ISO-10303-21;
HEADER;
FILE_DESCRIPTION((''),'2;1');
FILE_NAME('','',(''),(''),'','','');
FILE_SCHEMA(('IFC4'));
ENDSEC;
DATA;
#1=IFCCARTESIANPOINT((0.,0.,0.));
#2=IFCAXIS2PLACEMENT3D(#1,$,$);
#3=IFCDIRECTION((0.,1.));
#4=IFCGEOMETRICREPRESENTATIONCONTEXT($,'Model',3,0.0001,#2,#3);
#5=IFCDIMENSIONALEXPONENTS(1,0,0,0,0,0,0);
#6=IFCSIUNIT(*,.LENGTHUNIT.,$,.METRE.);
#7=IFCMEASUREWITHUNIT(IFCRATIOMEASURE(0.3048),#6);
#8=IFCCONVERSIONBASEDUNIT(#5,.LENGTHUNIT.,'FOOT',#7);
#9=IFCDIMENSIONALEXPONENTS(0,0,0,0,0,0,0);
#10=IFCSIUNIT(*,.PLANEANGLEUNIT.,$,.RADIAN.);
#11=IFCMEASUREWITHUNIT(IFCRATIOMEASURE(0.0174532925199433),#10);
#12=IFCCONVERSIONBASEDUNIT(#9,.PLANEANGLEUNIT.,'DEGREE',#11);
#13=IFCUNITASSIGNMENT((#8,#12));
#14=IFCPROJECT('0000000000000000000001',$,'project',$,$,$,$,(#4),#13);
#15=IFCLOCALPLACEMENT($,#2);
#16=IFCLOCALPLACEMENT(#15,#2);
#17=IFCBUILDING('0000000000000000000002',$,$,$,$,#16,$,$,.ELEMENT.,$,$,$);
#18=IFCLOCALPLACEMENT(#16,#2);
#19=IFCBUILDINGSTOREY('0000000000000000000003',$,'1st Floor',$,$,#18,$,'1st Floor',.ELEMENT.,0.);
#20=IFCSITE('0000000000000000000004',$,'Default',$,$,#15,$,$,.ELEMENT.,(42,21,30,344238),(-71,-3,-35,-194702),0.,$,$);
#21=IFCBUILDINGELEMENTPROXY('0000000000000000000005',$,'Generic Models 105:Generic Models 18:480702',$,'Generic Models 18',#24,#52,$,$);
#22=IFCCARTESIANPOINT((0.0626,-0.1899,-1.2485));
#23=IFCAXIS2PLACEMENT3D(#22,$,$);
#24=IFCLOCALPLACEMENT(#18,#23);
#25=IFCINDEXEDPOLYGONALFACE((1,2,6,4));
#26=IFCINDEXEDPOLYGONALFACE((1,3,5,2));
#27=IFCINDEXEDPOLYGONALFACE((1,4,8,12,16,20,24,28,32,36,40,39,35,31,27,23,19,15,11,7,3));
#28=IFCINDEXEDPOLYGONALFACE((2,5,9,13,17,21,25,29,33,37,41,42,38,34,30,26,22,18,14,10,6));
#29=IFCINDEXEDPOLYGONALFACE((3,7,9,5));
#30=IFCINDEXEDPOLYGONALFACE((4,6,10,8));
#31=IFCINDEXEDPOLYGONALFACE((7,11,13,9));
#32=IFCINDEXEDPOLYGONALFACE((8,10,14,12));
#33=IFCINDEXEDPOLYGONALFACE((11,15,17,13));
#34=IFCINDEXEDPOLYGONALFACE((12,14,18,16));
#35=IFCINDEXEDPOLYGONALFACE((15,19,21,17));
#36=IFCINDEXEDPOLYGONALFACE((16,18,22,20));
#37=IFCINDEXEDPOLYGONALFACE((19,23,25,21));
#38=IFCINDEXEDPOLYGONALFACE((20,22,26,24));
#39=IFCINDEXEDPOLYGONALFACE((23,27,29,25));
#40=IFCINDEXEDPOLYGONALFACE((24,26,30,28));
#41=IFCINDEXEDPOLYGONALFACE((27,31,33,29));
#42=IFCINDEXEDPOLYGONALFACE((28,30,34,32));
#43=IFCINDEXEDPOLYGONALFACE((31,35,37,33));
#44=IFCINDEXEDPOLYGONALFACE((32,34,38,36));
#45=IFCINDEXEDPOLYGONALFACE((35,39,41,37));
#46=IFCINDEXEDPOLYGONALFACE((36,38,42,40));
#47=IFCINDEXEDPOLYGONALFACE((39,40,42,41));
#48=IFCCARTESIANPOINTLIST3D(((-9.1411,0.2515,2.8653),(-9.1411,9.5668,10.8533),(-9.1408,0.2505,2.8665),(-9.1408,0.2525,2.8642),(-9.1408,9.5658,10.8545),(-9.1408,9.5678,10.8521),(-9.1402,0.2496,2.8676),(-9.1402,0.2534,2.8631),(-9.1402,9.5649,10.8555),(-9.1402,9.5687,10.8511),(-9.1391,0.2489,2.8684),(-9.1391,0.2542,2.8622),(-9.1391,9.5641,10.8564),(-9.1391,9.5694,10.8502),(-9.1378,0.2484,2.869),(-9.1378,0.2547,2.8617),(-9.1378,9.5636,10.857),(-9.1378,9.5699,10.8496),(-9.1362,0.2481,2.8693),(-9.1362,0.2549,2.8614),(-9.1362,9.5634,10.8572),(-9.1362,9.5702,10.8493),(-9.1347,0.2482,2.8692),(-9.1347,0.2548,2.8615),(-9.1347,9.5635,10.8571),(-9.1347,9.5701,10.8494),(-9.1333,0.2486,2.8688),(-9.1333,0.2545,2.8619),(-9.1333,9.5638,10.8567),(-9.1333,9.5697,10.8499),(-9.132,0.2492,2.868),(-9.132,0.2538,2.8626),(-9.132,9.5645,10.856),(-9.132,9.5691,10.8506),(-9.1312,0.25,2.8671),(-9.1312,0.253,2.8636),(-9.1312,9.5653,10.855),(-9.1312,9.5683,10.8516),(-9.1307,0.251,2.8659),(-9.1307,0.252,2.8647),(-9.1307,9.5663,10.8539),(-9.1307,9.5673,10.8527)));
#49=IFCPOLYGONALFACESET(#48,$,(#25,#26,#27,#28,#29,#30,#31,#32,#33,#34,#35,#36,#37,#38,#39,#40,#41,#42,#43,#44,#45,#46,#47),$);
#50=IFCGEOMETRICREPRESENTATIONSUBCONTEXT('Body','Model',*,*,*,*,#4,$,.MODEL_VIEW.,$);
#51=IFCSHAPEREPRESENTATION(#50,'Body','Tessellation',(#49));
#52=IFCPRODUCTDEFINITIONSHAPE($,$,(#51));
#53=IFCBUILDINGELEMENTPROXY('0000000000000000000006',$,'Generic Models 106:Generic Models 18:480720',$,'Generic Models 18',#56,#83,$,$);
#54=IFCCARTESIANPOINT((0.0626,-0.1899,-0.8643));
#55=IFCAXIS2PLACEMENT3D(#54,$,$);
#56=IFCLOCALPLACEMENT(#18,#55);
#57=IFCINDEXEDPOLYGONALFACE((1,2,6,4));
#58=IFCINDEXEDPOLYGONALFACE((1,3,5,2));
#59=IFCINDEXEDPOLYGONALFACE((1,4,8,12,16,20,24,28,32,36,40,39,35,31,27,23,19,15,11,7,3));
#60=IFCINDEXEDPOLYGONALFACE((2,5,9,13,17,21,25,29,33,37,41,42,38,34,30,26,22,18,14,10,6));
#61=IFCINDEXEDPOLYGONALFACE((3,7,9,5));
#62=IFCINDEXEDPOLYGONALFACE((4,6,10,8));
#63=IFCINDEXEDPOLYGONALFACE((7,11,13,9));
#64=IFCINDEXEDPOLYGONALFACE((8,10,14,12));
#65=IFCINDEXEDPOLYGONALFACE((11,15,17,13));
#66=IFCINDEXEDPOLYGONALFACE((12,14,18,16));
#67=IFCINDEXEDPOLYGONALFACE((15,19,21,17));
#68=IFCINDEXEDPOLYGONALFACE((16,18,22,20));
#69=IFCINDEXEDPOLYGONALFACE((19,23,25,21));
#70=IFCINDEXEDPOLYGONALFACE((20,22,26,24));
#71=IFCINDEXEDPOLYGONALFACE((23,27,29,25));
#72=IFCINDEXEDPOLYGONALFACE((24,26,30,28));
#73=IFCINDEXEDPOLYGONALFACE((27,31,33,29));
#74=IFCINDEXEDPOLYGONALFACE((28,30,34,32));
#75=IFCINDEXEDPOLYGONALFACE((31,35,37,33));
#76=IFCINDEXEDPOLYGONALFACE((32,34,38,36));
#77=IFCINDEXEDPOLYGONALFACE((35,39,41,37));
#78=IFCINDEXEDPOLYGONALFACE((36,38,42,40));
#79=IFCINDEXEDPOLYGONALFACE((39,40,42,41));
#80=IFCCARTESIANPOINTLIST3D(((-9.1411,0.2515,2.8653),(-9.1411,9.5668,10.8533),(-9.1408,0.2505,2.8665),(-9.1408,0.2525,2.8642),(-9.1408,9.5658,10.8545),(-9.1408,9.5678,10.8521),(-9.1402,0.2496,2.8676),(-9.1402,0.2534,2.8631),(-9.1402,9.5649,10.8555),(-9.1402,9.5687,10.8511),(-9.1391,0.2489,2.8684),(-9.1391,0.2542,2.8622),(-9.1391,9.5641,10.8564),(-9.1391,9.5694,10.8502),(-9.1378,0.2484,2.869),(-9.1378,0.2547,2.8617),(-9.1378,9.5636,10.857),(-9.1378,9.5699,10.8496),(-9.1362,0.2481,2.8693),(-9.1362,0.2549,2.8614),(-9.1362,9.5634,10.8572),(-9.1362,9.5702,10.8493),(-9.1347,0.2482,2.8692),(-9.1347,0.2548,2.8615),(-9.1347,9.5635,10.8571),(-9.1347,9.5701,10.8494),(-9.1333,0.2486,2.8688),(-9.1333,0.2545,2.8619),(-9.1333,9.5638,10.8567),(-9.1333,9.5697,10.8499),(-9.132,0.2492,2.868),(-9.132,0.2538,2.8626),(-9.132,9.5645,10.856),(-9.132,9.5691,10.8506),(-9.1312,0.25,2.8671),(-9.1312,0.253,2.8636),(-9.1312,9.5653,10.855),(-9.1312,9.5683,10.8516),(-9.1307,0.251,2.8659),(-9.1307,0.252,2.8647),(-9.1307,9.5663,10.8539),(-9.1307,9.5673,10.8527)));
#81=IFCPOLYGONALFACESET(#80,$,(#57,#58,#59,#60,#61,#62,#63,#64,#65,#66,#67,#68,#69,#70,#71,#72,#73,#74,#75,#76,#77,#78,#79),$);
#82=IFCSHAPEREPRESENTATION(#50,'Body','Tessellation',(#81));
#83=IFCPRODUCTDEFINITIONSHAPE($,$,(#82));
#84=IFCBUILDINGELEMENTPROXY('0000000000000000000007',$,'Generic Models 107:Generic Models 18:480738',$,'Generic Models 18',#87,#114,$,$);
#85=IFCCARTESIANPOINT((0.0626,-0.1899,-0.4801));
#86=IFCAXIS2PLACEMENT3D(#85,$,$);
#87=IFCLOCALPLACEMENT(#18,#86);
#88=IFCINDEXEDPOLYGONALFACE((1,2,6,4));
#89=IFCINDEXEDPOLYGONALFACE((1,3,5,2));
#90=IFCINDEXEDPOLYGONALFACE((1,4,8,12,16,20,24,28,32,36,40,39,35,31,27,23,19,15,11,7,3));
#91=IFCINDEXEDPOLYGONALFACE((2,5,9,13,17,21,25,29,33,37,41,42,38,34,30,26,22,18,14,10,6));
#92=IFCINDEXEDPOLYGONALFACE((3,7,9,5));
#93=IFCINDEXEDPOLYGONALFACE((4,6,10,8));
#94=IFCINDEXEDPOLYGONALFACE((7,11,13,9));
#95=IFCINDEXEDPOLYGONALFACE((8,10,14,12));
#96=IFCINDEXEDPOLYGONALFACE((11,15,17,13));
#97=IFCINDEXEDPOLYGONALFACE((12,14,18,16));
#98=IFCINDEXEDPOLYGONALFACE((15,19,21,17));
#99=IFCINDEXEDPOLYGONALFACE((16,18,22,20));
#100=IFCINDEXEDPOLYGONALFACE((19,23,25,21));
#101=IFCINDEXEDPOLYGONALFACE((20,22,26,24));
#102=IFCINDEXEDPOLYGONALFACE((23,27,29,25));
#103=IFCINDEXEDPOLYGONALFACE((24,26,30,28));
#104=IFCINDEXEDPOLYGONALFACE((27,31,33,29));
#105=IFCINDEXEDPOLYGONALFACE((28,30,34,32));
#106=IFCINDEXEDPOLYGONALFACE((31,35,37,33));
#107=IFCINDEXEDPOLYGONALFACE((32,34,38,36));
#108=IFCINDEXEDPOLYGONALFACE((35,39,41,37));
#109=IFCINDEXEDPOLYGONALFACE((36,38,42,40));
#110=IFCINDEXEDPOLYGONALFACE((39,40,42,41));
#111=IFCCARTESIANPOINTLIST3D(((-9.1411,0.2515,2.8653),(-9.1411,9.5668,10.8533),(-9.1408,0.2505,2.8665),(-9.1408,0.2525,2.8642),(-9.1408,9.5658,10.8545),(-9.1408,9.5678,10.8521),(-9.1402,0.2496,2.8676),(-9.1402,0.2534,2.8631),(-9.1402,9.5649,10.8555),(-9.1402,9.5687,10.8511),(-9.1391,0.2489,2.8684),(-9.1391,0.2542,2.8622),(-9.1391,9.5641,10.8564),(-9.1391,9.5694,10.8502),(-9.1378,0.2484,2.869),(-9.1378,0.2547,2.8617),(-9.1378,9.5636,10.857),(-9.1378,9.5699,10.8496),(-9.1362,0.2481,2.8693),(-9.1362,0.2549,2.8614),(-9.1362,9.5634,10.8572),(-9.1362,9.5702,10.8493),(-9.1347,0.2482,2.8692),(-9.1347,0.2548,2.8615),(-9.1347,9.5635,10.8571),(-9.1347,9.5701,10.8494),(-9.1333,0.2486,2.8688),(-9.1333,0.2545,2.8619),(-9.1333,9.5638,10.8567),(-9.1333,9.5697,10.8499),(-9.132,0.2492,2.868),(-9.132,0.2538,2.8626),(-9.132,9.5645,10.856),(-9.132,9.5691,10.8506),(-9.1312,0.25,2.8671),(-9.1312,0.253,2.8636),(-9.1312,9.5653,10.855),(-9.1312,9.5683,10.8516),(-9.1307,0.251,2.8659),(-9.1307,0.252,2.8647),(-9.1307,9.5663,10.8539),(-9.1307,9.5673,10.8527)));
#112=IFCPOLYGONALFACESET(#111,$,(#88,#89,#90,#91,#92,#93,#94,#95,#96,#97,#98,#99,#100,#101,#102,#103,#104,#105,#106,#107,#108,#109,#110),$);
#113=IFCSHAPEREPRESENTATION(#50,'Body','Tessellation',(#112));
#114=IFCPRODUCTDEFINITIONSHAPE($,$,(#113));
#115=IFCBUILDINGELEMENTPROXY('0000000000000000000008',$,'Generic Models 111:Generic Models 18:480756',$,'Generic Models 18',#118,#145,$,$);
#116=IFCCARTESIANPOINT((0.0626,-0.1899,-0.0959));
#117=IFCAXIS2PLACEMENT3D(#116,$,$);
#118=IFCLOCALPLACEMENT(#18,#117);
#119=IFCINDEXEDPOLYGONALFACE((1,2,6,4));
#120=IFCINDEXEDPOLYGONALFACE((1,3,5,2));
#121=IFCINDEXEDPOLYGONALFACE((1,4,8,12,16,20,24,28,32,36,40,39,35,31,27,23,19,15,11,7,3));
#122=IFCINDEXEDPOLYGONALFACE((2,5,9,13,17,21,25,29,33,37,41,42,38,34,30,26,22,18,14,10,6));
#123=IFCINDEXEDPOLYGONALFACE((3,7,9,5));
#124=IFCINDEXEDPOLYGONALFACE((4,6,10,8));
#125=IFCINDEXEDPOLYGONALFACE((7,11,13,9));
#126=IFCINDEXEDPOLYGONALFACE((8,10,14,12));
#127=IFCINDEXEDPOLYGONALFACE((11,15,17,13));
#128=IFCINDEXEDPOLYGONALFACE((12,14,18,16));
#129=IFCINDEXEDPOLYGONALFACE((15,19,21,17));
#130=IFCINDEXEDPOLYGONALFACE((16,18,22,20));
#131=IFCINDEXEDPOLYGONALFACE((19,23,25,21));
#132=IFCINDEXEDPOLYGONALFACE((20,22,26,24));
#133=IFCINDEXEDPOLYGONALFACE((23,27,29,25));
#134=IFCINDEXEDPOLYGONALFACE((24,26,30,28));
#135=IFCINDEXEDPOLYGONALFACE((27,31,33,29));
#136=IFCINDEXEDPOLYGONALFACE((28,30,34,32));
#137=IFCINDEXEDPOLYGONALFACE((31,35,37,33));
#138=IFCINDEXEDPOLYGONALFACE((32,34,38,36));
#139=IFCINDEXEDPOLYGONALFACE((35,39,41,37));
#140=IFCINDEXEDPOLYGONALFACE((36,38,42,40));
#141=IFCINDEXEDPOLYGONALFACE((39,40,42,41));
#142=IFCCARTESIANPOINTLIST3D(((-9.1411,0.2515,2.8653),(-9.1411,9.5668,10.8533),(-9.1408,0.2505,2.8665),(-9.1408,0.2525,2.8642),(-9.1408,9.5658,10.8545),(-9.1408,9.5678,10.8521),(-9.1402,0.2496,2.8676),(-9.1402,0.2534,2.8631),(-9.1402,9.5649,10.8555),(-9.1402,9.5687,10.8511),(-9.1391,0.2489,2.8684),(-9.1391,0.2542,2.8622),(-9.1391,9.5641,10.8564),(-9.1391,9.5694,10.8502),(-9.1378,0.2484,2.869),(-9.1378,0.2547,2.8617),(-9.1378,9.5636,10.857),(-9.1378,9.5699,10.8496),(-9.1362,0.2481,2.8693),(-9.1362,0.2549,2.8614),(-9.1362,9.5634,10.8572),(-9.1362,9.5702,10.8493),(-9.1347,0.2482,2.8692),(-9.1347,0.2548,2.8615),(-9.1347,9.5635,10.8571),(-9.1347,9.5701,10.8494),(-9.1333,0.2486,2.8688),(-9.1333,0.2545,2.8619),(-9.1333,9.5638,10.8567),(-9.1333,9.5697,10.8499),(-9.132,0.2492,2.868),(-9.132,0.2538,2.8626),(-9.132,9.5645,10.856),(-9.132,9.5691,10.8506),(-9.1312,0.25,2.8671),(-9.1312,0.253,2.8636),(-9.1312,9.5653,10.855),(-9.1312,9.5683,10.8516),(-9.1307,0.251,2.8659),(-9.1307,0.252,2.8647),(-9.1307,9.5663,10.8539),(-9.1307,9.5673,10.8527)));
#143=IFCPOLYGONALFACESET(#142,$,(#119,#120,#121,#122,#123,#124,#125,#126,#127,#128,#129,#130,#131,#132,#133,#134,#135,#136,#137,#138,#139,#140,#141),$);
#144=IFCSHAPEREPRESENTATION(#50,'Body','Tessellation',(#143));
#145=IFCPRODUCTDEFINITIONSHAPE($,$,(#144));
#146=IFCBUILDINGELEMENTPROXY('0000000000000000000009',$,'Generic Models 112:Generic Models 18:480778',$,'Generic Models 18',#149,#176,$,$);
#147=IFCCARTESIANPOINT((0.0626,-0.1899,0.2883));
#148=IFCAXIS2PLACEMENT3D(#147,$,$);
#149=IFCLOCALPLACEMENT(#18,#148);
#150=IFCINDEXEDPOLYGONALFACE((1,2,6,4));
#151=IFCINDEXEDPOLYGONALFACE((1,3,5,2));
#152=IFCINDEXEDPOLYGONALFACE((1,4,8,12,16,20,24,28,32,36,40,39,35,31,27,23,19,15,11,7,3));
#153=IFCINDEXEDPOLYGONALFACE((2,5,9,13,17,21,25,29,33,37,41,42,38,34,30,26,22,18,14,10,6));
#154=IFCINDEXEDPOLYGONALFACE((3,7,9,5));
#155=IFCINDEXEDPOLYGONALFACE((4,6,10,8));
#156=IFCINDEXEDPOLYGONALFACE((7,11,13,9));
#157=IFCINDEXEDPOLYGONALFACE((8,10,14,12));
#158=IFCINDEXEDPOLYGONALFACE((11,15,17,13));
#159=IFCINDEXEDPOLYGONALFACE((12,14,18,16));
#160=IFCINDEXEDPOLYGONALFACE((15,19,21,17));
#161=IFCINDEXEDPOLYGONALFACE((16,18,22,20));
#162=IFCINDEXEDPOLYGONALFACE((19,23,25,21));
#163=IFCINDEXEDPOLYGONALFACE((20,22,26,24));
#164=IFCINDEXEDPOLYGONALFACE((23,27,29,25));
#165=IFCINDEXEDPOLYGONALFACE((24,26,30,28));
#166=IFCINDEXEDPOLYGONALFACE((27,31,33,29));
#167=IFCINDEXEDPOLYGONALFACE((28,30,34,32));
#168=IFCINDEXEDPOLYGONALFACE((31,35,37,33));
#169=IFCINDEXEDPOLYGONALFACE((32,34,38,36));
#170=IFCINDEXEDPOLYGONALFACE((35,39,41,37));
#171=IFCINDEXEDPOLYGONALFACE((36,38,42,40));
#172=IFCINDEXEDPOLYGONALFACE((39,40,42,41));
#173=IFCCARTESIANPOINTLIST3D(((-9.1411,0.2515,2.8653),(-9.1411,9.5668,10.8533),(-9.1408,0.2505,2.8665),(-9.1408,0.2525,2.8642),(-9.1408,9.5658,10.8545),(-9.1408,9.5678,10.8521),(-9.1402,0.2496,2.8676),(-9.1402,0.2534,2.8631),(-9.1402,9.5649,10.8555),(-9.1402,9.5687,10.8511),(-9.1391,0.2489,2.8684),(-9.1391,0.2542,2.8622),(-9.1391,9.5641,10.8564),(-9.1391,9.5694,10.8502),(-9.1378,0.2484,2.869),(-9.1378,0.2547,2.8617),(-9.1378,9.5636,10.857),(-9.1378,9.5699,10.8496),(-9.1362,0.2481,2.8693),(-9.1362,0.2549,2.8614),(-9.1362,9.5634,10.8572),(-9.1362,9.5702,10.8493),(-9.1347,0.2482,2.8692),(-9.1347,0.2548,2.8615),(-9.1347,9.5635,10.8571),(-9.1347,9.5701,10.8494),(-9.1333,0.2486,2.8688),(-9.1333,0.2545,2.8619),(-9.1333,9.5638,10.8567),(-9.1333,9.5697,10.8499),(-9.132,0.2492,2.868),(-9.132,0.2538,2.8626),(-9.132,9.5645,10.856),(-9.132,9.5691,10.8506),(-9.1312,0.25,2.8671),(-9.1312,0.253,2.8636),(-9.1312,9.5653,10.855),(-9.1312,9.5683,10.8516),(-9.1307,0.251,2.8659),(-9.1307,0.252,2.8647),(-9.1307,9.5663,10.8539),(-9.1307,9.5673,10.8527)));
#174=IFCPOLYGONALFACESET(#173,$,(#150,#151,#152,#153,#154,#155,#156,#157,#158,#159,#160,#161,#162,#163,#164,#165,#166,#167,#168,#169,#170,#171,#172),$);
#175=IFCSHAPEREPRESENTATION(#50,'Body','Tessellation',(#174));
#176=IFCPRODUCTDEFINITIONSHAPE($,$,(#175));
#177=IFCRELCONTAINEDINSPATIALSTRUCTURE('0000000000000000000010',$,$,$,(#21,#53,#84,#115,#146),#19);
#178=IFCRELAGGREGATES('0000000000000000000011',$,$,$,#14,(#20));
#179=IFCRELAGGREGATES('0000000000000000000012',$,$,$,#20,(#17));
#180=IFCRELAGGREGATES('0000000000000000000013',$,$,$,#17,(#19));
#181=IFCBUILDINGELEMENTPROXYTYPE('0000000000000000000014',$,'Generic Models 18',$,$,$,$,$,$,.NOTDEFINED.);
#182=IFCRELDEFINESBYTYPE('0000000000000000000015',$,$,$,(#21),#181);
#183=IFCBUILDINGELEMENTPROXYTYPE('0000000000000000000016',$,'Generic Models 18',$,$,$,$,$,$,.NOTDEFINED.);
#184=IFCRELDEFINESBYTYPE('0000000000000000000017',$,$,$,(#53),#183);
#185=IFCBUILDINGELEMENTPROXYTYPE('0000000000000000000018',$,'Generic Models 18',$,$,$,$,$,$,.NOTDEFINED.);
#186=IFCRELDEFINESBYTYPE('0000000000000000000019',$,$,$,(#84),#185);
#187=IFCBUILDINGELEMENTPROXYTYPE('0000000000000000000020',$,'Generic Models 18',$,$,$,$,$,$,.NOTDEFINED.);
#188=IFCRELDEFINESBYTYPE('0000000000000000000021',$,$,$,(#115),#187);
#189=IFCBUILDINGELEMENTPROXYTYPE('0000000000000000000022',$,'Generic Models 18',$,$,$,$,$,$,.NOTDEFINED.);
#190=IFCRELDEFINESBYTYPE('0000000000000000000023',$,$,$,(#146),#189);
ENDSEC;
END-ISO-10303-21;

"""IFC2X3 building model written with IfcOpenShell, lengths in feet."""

from ifc_helpers import new_model, entity, si_unit, converted_unit, direction, frame, origin, origin_2d_with_axis, place, context, subcontext, project, spatial, circle, extrude, source, transform, mapped, type_object, type_shapes, element, save


model = new_model("IFC2X3")

# Units and contexts
model_context = context("Model", 3, precision=0.0001, world=origin(), true_north=direction((0.0, 1.0)))
body_context = subcontext(model_context, "Body", "Model", "MODEL_VIEW")
ifc_project = project(units=[converted_unit("LENGTHUNIT", "FOOT", entity("IfcRatioMeasure", 0.3048), si_unit("LENGTHUNIT", "METRE"), dimensions=[1, 0, 0, 0, 0, 0, 0]), converted_unit("PLANEANGLEUNIT", "DEGREE", entity("IfcRatioMeasure", 0.0174532925199433), si_unit("PLANEANGLEUNIT", "RADIAN"), dimensions=[0, 0, 0, 0, 0, 0, 0])], contexts=[model_context])

# Site, building, storey
site_placement = place(None, origin())
site = spatial("IfcSite", under=ifc_project, at=site_placement, Name="Default", CompositionType="ELEMENT", RefLatitude=(42, 21, 30, 344238), RefLongitude=(-71, -3, -35, -194702), RefElevation=0.0)
building_placement = place(site_placement, origin())
building = spatial("IfcBuilding", under=site, at=building_placement, CompositionType="ELEMENT")
storey_placement = place(building_placement, origin())
storey = spatial("IfcBuildingStorey", under=building, at=storey_placement, Name="1st Floor", LongName="1st Floor", CompositionType="ELEMENT", Elevation=0.0)

# Building element proxies
building_element_proxy_type_1 = type_object("IfcBuildingElementProxyType", Name="Generic Models 18", PredefinedType="NOTDEFINED")
shared_shape_1 = source(origin(), body_context, "Body", "SweptSolid", [
    extrude(circle(Radius=0.0052, at=origin_2d_with_axis()), frame((-9.1359, 0.2515, 2.8653), z_axis=(0.0, 0.759118, 0.650953), x_axis=(-1.0, 0.0, 0.0)), (0.0, 0.0, 1.0), 12.2712),
])
type_shapes(building_element_proxy_type_1, [shared_shape_1])
proxy_1_placement = place(storey_placement, frame((0.0626, -0.1899, -1.2485)))
element("IfcBuildingElementProxy", 1, at=proxy_1_placement, inside=storey, type_object=building_element_proxy_type_1, Name="Generic Models 105:Generic Models 18:480702", ObjectType="Generic Models 18", context=body_context, shape_type="MappedRepresentation", body=[
    mapped(shared_shape_1, transform((0.0, 0.0, 0.0), scale=1.0)),
])
building_element_proxy_type_2 = type_object("IfcBuildingElementProxyType", Name="Generic Models 18", PredefinedType="NOTDEFINED")
shared_shape_2 = source(origin(), body_context, "Body", "SweptSolid", [
    extrude(circle(Radius=0.0052, at=origin_2d_with_axis()), frame((-9.1359, 0.2515, 2.8653), z_axis=(0.0, 0.759118, 0.650953), x_axis=(-1.0, 0.0, 0.0)), (0.0, 0.0, 1.0), 12.2712),
])
type_shapes(building_element_proxy_type_2, [shared_shape_2])
proxy_2_placement = place(storey_placement, frame((0.0626, -0.1899, -0.8643)))
element("IfcBuildingElementProxy", 2, at=proxy_2_placement, inside=storey, type_object=building_element_proxy_type_2, Name="Generic Models 106:Generic Models 18:480720", ObjectType="Generic Models 18", context=body_context, shape_type="MappedRepresentation", body=[
    mapped(shared_shape_2, transform((0.0, 0.0, 0.0), scale=1.0)),
])
building_element_proxy_type_3 = type_object("IfcBuildingElementProxyType", Name="Generic Models 18", PredefinedType="NOTDEFINED")
shared_shape_3 = source(origin(), body_context, "Body", "SweptSolid", [
    extrude(circle(Radius=0.0052, at=origin_2d_with_axis()), frame((-9.1359, 0.2515, 2.8653), z_axis=(0.0, 0.759118, 0.650953), x_axis=(-1.0, 0.0, 0.0)), (0.0, 0.0, 1.0), 12.2712),
])
type_shapes(building_element_proxy_type_3, [shared_shape_3])
proxy_3_placement = place(storey_placement, frame((0.0626, -0.1899, -0.4801)))
element("IfcBuildingElementProxy", 3, at=proxy_3_placement, inside=storey, type_object=building_element_proxy_type_3, Name="Generic Models 107:Generic Models 18:480738", ObjectType="Generic Models 18", context=body_context, shape_type="MappedRepresentation", body=[
    mapped(shared_shape_3, transform((0.0, 0.0, 0.0), scale=1.0)),
])
building_element_proxy_type_4 = type_object("IfcBuildingElementProxyType", Name="Generic Models 18", PredefinedType="NOTDEFINED")
shared_shape_4 = source(origin(), body_context, "Body", "SweptSolid", [
    extrude(circle(Radius=0.0052, at=origin_2d_with_axis()), frame((-9.1359, 0.2515, 2.8653), z_axis=(0.0, 0.759118, 0.650953), x_axis=(-1.0, 0.0, 0.0)), (0.0, 0.0, 1.0), 12.2712),
])
type_shapes(building_element_proxy_type_4, [shared_shape_4])
proxy_4_placement = place(storey_placement, frame((0.0626, -0.1899, -0.0959)))
element("IfcBuildingElementProxy", 4, at=proxy_4_placement, inside=storey, type_object=building_element_proxy_type_4, Name="Generic Models 111:Generic Models 18:480756", ObjectType="Generic Models 18", context=body_context, shape_type="MappedRepresentation", body=[
    mapped(shared_shape_4, transform((0.0, 0.0, 0.0), scale=1.0)),
])
building_element_proxy_type_5 = type_object("IfcBuildingElementProxyType", Name="Generic Models 18", PredefinedType="NOTDEFINED")
shared_shape_5 = source(origin(), body_context, "Body", "SweptSolid", [
    extrude(circle(Radius=0.0052, at=origin_2d_with_axis()), frame((-9.1359, 0.2515, 2.8653), z_axis=(0.0, 0.759118, 0.650953), x_axis=(-1.0, 0.0, 0.0)), (0.0, 0.0, 1.0), 12.2712),
])
type_shapes(building_element_proxy_type_5, [shared_shape_5])
proxy_5_placement = place(storey_placement, frame((0.0626, -0.1899, 0.2883)))
element("IfcBuildingElementProxy", 5, at=proxy_5_placement, inside=storey, type_object=building_element_proxy_type_5, Name="Generic Models 112:Generic Models 18:480778", ObjectType="Generic Models 18", context=body_context, shape_type="MappedRepresentation", body=[
    mapped(shared_shape_5, transform((0.0, 0.0, 0.0), scale=1.0)),
])

save(model, "model.ifc")
